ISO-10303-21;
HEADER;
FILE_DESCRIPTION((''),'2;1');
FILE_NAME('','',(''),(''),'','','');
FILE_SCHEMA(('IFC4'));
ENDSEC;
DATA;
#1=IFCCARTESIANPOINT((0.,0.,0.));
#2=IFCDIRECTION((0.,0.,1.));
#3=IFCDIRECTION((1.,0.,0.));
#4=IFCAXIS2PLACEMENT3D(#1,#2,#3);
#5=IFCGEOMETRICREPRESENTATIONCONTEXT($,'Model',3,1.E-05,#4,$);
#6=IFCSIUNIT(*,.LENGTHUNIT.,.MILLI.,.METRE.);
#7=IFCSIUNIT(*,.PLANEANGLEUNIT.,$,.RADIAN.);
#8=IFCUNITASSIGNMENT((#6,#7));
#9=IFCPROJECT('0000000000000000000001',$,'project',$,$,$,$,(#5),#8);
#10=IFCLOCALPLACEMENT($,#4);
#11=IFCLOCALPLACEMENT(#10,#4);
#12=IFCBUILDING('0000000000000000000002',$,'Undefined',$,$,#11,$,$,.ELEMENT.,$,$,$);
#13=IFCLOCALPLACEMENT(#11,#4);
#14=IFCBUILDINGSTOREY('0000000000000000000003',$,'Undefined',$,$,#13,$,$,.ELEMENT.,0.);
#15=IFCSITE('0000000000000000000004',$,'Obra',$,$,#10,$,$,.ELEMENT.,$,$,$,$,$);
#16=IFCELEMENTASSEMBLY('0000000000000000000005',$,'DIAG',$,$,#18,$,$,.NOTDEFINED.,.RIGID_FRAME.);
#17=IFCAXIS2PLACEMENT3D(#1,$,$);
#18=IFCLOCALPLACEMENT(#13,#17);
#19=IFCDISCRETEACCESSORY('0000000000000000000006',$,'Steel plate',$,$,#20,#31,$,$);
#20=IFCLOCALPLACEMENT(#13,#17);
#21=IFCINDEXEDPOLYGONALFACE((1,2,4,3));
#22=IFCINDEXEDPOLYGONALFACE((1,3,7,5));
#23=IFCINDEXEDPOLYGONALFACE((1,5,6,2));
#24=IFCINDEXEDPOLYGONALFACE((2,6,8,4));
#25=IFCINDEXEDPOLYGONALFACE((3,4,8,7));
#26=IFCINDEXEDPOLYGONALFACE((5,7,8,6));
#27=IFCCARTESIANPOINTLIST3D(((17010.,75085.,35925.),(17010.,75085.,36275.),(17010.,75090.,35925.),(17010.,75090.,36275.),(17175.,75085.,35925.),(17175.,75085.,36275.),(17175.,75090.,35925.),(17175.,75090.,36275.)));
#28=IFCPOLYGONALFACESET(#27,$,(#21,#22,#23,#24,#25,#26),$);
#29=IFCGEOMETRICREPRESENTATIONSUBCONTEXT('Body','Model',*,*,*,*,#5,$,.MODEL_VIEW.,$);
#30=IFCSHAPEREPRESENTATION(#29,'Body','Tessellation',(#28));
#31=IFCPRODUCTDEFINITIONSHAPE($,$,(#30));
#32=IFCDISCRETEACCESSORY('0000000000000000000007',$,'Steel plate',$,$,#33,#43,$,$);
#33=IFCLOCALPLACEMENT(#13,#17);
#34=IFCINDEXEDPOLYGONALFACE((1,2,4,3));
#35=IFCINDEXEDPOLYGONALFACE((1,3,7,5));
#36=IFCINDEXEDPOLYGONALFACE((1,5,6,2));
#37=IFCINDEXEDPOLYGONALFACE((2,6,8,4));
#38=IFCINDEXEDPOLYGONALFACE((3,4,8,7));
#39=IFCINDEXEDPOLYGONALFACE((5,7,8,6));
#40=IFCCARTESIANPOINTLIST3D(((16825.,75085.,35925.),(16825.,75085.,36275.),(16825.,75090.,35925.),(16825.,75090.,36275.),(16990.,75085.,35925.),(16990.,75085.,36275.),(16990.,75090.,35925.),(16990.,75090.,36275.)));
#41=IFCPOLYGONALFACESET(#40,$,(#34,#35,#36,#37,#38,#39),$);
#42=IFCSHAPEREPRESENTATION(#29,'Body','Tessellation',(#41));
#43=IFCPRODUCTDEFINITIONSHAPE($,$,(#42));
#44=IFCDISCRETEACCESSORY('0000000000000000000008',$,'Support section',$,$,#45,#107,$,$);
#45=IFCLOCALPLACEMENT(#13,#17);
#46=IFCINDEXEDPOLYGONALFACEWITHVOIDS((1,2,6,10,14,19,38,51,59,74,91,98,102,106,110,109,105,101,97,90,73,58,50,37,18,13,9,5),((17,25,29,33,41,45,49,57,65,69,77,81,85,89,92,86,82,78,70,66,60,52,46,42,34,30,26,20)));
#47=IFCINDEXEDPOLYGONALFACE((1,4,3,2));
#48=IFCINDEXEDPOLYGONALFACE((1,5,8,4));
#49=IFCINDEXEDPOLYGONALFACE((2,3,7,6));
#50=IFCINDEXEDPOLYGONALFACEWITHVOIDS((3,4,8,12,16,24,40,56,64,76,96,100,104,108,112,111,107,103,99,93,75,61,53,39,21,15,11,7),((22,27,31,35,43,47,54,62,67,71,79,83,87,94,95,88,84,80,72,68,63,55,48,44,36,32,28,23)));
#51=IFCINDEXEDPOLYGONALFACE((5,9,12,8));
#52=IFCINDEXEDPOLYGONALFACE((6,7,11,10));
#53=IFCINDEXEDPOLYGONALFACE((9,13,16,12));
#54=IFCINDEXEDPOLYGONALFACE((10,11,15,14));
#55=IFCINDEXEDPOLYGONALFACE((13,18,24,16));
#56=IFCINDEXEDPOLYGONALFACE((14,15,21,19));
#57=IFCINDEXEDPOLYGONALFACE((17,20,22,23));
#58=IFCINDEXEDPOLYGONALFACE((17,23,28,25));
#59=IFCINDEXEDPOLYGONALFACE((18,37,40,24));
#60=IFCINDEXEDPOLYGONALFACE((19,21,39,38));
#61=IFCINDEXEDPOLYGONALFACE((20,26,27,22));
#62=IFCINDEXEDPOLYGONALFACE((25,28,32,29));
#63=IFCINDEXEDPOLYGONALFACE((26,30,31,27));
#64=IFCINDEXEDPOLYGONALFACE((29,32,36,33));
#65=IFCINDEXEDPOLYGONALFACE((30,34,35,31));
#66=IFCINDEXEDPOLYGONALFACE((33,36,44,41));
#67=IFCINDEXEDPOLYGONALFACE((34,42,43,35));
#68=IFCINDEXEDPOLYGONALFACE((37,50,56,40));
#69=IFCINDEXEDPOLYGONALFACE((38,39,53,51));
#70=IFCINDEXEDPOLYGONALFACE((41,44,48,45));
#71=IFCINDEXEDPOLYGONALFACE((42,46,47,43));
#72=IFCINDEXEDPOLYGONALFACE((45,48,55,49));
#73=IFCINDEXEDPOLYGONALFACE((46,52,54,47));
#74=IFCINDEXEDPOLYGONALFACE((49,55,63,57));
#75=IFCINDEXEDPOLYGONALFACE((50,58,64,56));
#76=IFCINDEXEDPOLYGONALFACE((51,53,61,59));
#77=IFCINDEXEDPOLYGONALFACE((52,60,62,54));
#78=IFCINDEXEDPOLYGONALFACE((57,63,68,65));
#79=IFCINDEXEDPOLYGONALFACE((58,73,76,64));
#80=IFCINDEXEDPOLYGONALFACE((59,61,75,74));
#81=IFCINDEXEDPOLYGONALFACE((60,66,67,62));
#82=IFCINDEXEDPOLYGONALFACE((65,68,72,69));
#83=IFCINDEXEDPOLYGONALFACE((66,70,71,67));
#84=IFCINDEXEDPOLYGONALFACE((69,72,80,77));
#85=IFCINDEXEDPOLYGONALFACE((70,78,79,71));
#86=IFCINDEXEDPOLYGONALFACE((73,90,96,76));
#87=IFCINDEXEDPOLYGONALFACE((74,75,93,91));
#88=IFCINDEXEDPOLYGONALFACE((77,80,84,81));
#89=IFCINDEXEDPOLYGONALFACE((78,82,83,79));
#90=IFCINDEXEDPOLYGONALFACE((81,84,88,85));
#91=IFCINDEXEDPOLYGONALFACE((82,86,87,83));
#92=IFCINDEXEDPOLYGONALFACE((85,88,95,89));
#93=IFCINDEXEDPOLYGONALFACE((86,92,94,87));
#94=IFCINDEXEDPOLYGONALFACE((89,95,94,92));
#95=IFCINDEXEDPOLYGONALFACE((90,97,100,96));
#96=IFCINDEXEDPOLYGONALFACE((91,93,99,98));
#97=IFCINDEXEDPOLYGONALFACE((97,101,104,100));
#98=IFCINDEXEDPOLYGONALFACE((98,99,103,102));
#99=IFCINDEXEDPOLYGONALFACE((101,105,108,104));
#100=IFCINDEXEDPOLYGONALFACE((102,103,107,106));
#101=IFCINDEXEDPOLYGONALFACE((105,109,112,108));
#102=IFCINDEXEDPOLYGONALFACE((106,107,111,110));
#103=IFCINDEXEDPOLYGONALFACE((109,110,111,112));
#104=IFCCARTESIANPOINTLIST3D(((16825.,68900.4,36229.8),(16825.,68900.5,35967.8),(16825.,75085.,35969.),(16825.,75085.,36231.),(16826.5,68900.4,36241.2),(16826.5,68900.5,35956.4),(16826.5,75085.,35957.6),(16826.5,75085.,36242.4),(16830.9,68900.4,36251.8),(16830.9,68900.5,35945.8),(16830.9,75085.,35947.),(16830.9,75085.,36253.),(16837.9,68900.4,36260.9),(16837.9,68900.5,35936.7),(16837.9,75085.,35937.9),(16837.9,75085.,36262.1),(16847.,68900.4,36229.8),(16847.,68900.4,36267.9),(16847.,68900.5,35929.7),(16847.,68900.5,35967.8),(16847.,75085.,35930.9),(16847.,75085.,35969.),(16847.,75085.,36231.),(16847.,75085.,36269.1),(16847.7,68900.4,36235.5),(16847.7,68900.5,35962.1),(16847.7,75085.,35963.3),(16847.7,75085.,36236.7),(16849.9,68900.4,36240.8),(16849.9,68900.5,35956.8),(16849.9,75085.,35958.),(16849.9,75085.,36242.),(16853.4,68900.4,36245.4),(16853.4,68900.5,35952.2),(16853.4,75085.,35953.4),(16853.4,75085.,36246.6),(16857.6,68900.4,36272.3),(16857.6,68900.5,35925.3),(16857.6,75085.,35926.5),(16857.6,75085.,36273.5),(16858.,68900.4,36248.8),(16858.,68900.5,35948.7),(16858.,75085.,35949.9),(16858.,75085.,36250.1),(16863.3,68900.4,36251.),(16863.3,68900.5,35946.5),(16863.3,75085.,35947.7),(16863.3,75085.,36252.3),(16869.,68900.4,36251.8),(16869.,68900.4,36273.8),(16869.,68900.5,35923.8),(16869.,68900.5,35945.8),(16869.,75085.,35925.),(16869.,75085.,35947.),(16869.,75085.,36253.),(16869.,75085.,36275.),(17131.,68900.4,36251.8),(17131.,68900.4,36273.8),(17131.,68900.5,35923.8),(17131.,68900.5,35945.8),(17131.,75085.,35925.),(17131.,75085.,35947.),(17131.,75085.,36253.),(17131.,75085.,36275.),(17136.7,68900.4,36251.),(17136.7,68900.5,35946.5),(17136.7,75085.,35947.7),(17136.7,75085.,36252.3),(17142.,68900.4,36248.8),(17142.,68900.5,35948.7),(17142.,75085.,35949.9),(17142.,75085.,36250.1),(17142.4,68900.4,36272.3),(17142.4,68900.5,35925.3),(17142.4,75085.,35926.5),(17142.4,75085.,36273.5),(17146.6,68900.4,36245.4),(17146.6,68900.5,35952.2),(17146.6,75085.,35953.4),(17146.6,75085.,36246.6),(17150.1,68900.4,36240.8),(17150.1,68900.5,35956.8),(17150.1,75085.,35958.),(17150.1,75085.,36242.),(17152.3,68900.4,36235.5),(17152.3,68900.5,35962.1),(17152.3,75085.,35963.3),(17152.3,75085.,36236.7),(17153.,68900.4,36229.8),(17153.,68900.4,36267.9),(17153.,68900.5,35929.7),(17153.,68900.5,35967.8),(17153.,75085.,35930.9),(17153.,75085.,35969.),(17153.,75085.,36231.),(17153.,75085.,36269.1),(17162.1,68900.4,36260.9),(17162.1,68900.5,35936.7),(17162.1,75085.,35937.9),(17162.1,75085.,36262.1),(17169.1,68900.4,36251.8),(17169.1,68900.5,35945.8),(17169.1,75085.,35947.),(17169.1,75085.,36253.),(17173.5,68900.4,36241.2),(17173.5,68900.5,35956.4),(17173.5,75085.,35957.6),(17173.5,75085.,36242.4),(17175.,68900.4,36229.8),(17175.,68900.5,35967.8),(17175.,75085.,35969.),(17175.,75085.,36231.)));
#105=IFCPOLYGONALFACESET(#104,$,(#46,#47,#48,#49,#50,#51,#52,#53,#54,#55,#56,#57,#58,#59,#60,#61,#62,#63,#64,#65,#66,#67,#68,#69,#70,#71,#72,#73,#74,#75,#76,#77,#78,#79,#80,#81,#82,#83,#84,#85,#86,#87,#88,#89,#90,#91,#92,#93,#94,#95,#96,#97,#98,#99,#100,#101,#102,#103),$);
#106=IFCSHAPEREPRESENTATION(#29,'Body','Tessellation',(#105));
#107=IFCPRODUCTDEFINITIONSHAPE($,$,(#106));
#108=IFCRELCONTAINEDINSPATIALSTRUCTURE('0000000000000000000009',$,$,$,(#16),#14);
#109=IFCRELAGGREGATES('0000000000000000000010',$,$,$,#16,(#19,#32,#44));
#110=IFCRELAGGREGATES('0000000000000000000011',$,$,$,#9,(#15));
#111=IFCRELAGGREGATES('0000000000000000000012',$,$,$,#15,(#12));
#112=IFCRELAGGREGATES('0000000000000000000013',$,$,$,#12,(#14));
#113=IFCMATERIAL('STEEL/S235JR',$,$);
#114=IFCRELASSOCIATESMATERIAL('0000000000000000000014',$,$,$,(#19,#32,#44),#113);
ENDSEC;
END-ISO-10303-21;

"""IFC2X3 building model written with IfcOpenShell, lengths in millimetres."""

from ifc_helpers import new_model, si_unit, frame, origin_with_axes, origin_2d_with_axis, place, context, subcontext, project, spatial, polyline, hollow_rectangle, outline, extrude, clip, halfspace, material, element, aggregate, save


model = new_model("IFC2X3")

# Units and contexts
model_context = context("Model", 3, precision=1e-05, world=origin_with_axes())
body_context = subcontext(model_context, "Body", "Model", "MODEL_VIEW")
ifc_project = project(units=[si_unit("LENGTHUNIT", "METRE", prefix="MILLI"), si_unit("PLANEANGLEUNIT", "RADIAN")], contexts=[model_context])

# Site, building, storey
site_placement = place(None, origin_with_axes())
site = spatial("IfcSite", under=ifc_project, at=site_placement, Name="Obra", CompositionType="ELEMENT")
building_placement = place(site_placement, origin_with_axes())
building = spatial("IfcBuilding", under=site, at=building_placement, Name="Undefined", CompositionType="ELEMENT")
storey_placement = place(building_placement, origin_with_axes())
storey = spatial("IfcBuildingStorey", under=building, at=storey_placement, Name="Undefined", CompositionType="ELEMENT", Elevation=0.0)

# Element assembly
assembly_1_placement = place(storey_placement, origin_with_axes())
assembly_1 = element("IfcElementAssembly", 1, at=assembly_1_placement, inside=storey, Name="DIAG", AssemblyPlace="NOTDEFINED", PredefinedType="RIGID_FRAME")
ifc_material_1 = material(Name="STEEL/S235JR")

# Discrete accessories
discrete_accessory_1_placement = place(assembly_1_placement, frame((17175.0, 75087.5, 35925.0), z_axis=(0.0, 1.0, 0.0), x_axis=(-1.0, 0.0, 0.0)))
discrete_accessory_1 = element("IfcDiscreteAccessory", 2, at=discrete_accessory_1_placement, material=ifc_material_1, Name="Steel plate", context=body_context, shape_type="SweptSolid", body=[
    extrude(outline(polyline([(0.0, 0.0), (165.0, 0.0), (165.0, 350.0), (0.0, 350.0), (0.0, 0.0)])), frame((0.0, 0.0, -2.5), z_axis=(0.0, 0.0, 1.0), x_axis=(1.0, 0.0, 0.0)), (0.0, 0.0, 1.0), 5.0),
])
discrete_accessory_2_placement = place(assembly_1_placement, frame((16990.0, 75087.5, 35925.0), z_axis=(0.0, 1.0, 0.0), x_axis=(-1.0, 0.0, 0.0)))
discrete_accessory_2 = element("IfcDiscreteAccessory", 3, at=discrete_accessory_2_placement, material=ifc_material_1, Name="Steel plate", context=body_context, shape_type="SweptSolid", body=[
    extrude(outline(polyline([(0.0, 0.0), (165.0, 0.0), (165.0, 350.0), (0.0, 350.0), (0.0, 0.0)])), frame((0.0, 0.0, -2.5), z_axis=(0.0, 0.0, 1.0), x_axis=(1.0, 0.0, 0.0)), (0.0, 0.0, 1.0), 5.0),
])
discrete_accessory_3_placement = place(assembly_1_placement, frame((17000.0, 68880.6, 36098.8), z_axis=(0.0, -0.000195, 1.0), x_axis=(0.0, 1.0, 0.000195)))
discrete_accessory_3 = element("IfcDiscreteAccessory", 4, at=discrete_accessory_3_placement, material=ifc_material_1, Name="Support section", context=body_context, shape_type="Clipping", body=[
    clip(extrude(hollow_rectangle(XDim=350.0, YDim=350.0, WallThickness=22.0, InnerFilletRadius=22.0, OuterFilletRadius=44.0, at=origin_2d_with_axis()), frame((6204.4, 0.0, 0.0), z_axis=(-1.0, 0.0, 0.0), x_axis=(0.0, -1.0, 0.0)), (0.0, 0.0, 1.0), 6184.6), halfspace(frame((20.0, 0.0, -175.0), z_axis=(1.0, 0.0, -0.000097), x_axis=(0.0, -1.0, 0.0)), True)),
])
aggregate(assembly_1, [discrete_accessory_1, discrete_accessory_2, discrete_accessory_3])

save(model, "model.ifc")
